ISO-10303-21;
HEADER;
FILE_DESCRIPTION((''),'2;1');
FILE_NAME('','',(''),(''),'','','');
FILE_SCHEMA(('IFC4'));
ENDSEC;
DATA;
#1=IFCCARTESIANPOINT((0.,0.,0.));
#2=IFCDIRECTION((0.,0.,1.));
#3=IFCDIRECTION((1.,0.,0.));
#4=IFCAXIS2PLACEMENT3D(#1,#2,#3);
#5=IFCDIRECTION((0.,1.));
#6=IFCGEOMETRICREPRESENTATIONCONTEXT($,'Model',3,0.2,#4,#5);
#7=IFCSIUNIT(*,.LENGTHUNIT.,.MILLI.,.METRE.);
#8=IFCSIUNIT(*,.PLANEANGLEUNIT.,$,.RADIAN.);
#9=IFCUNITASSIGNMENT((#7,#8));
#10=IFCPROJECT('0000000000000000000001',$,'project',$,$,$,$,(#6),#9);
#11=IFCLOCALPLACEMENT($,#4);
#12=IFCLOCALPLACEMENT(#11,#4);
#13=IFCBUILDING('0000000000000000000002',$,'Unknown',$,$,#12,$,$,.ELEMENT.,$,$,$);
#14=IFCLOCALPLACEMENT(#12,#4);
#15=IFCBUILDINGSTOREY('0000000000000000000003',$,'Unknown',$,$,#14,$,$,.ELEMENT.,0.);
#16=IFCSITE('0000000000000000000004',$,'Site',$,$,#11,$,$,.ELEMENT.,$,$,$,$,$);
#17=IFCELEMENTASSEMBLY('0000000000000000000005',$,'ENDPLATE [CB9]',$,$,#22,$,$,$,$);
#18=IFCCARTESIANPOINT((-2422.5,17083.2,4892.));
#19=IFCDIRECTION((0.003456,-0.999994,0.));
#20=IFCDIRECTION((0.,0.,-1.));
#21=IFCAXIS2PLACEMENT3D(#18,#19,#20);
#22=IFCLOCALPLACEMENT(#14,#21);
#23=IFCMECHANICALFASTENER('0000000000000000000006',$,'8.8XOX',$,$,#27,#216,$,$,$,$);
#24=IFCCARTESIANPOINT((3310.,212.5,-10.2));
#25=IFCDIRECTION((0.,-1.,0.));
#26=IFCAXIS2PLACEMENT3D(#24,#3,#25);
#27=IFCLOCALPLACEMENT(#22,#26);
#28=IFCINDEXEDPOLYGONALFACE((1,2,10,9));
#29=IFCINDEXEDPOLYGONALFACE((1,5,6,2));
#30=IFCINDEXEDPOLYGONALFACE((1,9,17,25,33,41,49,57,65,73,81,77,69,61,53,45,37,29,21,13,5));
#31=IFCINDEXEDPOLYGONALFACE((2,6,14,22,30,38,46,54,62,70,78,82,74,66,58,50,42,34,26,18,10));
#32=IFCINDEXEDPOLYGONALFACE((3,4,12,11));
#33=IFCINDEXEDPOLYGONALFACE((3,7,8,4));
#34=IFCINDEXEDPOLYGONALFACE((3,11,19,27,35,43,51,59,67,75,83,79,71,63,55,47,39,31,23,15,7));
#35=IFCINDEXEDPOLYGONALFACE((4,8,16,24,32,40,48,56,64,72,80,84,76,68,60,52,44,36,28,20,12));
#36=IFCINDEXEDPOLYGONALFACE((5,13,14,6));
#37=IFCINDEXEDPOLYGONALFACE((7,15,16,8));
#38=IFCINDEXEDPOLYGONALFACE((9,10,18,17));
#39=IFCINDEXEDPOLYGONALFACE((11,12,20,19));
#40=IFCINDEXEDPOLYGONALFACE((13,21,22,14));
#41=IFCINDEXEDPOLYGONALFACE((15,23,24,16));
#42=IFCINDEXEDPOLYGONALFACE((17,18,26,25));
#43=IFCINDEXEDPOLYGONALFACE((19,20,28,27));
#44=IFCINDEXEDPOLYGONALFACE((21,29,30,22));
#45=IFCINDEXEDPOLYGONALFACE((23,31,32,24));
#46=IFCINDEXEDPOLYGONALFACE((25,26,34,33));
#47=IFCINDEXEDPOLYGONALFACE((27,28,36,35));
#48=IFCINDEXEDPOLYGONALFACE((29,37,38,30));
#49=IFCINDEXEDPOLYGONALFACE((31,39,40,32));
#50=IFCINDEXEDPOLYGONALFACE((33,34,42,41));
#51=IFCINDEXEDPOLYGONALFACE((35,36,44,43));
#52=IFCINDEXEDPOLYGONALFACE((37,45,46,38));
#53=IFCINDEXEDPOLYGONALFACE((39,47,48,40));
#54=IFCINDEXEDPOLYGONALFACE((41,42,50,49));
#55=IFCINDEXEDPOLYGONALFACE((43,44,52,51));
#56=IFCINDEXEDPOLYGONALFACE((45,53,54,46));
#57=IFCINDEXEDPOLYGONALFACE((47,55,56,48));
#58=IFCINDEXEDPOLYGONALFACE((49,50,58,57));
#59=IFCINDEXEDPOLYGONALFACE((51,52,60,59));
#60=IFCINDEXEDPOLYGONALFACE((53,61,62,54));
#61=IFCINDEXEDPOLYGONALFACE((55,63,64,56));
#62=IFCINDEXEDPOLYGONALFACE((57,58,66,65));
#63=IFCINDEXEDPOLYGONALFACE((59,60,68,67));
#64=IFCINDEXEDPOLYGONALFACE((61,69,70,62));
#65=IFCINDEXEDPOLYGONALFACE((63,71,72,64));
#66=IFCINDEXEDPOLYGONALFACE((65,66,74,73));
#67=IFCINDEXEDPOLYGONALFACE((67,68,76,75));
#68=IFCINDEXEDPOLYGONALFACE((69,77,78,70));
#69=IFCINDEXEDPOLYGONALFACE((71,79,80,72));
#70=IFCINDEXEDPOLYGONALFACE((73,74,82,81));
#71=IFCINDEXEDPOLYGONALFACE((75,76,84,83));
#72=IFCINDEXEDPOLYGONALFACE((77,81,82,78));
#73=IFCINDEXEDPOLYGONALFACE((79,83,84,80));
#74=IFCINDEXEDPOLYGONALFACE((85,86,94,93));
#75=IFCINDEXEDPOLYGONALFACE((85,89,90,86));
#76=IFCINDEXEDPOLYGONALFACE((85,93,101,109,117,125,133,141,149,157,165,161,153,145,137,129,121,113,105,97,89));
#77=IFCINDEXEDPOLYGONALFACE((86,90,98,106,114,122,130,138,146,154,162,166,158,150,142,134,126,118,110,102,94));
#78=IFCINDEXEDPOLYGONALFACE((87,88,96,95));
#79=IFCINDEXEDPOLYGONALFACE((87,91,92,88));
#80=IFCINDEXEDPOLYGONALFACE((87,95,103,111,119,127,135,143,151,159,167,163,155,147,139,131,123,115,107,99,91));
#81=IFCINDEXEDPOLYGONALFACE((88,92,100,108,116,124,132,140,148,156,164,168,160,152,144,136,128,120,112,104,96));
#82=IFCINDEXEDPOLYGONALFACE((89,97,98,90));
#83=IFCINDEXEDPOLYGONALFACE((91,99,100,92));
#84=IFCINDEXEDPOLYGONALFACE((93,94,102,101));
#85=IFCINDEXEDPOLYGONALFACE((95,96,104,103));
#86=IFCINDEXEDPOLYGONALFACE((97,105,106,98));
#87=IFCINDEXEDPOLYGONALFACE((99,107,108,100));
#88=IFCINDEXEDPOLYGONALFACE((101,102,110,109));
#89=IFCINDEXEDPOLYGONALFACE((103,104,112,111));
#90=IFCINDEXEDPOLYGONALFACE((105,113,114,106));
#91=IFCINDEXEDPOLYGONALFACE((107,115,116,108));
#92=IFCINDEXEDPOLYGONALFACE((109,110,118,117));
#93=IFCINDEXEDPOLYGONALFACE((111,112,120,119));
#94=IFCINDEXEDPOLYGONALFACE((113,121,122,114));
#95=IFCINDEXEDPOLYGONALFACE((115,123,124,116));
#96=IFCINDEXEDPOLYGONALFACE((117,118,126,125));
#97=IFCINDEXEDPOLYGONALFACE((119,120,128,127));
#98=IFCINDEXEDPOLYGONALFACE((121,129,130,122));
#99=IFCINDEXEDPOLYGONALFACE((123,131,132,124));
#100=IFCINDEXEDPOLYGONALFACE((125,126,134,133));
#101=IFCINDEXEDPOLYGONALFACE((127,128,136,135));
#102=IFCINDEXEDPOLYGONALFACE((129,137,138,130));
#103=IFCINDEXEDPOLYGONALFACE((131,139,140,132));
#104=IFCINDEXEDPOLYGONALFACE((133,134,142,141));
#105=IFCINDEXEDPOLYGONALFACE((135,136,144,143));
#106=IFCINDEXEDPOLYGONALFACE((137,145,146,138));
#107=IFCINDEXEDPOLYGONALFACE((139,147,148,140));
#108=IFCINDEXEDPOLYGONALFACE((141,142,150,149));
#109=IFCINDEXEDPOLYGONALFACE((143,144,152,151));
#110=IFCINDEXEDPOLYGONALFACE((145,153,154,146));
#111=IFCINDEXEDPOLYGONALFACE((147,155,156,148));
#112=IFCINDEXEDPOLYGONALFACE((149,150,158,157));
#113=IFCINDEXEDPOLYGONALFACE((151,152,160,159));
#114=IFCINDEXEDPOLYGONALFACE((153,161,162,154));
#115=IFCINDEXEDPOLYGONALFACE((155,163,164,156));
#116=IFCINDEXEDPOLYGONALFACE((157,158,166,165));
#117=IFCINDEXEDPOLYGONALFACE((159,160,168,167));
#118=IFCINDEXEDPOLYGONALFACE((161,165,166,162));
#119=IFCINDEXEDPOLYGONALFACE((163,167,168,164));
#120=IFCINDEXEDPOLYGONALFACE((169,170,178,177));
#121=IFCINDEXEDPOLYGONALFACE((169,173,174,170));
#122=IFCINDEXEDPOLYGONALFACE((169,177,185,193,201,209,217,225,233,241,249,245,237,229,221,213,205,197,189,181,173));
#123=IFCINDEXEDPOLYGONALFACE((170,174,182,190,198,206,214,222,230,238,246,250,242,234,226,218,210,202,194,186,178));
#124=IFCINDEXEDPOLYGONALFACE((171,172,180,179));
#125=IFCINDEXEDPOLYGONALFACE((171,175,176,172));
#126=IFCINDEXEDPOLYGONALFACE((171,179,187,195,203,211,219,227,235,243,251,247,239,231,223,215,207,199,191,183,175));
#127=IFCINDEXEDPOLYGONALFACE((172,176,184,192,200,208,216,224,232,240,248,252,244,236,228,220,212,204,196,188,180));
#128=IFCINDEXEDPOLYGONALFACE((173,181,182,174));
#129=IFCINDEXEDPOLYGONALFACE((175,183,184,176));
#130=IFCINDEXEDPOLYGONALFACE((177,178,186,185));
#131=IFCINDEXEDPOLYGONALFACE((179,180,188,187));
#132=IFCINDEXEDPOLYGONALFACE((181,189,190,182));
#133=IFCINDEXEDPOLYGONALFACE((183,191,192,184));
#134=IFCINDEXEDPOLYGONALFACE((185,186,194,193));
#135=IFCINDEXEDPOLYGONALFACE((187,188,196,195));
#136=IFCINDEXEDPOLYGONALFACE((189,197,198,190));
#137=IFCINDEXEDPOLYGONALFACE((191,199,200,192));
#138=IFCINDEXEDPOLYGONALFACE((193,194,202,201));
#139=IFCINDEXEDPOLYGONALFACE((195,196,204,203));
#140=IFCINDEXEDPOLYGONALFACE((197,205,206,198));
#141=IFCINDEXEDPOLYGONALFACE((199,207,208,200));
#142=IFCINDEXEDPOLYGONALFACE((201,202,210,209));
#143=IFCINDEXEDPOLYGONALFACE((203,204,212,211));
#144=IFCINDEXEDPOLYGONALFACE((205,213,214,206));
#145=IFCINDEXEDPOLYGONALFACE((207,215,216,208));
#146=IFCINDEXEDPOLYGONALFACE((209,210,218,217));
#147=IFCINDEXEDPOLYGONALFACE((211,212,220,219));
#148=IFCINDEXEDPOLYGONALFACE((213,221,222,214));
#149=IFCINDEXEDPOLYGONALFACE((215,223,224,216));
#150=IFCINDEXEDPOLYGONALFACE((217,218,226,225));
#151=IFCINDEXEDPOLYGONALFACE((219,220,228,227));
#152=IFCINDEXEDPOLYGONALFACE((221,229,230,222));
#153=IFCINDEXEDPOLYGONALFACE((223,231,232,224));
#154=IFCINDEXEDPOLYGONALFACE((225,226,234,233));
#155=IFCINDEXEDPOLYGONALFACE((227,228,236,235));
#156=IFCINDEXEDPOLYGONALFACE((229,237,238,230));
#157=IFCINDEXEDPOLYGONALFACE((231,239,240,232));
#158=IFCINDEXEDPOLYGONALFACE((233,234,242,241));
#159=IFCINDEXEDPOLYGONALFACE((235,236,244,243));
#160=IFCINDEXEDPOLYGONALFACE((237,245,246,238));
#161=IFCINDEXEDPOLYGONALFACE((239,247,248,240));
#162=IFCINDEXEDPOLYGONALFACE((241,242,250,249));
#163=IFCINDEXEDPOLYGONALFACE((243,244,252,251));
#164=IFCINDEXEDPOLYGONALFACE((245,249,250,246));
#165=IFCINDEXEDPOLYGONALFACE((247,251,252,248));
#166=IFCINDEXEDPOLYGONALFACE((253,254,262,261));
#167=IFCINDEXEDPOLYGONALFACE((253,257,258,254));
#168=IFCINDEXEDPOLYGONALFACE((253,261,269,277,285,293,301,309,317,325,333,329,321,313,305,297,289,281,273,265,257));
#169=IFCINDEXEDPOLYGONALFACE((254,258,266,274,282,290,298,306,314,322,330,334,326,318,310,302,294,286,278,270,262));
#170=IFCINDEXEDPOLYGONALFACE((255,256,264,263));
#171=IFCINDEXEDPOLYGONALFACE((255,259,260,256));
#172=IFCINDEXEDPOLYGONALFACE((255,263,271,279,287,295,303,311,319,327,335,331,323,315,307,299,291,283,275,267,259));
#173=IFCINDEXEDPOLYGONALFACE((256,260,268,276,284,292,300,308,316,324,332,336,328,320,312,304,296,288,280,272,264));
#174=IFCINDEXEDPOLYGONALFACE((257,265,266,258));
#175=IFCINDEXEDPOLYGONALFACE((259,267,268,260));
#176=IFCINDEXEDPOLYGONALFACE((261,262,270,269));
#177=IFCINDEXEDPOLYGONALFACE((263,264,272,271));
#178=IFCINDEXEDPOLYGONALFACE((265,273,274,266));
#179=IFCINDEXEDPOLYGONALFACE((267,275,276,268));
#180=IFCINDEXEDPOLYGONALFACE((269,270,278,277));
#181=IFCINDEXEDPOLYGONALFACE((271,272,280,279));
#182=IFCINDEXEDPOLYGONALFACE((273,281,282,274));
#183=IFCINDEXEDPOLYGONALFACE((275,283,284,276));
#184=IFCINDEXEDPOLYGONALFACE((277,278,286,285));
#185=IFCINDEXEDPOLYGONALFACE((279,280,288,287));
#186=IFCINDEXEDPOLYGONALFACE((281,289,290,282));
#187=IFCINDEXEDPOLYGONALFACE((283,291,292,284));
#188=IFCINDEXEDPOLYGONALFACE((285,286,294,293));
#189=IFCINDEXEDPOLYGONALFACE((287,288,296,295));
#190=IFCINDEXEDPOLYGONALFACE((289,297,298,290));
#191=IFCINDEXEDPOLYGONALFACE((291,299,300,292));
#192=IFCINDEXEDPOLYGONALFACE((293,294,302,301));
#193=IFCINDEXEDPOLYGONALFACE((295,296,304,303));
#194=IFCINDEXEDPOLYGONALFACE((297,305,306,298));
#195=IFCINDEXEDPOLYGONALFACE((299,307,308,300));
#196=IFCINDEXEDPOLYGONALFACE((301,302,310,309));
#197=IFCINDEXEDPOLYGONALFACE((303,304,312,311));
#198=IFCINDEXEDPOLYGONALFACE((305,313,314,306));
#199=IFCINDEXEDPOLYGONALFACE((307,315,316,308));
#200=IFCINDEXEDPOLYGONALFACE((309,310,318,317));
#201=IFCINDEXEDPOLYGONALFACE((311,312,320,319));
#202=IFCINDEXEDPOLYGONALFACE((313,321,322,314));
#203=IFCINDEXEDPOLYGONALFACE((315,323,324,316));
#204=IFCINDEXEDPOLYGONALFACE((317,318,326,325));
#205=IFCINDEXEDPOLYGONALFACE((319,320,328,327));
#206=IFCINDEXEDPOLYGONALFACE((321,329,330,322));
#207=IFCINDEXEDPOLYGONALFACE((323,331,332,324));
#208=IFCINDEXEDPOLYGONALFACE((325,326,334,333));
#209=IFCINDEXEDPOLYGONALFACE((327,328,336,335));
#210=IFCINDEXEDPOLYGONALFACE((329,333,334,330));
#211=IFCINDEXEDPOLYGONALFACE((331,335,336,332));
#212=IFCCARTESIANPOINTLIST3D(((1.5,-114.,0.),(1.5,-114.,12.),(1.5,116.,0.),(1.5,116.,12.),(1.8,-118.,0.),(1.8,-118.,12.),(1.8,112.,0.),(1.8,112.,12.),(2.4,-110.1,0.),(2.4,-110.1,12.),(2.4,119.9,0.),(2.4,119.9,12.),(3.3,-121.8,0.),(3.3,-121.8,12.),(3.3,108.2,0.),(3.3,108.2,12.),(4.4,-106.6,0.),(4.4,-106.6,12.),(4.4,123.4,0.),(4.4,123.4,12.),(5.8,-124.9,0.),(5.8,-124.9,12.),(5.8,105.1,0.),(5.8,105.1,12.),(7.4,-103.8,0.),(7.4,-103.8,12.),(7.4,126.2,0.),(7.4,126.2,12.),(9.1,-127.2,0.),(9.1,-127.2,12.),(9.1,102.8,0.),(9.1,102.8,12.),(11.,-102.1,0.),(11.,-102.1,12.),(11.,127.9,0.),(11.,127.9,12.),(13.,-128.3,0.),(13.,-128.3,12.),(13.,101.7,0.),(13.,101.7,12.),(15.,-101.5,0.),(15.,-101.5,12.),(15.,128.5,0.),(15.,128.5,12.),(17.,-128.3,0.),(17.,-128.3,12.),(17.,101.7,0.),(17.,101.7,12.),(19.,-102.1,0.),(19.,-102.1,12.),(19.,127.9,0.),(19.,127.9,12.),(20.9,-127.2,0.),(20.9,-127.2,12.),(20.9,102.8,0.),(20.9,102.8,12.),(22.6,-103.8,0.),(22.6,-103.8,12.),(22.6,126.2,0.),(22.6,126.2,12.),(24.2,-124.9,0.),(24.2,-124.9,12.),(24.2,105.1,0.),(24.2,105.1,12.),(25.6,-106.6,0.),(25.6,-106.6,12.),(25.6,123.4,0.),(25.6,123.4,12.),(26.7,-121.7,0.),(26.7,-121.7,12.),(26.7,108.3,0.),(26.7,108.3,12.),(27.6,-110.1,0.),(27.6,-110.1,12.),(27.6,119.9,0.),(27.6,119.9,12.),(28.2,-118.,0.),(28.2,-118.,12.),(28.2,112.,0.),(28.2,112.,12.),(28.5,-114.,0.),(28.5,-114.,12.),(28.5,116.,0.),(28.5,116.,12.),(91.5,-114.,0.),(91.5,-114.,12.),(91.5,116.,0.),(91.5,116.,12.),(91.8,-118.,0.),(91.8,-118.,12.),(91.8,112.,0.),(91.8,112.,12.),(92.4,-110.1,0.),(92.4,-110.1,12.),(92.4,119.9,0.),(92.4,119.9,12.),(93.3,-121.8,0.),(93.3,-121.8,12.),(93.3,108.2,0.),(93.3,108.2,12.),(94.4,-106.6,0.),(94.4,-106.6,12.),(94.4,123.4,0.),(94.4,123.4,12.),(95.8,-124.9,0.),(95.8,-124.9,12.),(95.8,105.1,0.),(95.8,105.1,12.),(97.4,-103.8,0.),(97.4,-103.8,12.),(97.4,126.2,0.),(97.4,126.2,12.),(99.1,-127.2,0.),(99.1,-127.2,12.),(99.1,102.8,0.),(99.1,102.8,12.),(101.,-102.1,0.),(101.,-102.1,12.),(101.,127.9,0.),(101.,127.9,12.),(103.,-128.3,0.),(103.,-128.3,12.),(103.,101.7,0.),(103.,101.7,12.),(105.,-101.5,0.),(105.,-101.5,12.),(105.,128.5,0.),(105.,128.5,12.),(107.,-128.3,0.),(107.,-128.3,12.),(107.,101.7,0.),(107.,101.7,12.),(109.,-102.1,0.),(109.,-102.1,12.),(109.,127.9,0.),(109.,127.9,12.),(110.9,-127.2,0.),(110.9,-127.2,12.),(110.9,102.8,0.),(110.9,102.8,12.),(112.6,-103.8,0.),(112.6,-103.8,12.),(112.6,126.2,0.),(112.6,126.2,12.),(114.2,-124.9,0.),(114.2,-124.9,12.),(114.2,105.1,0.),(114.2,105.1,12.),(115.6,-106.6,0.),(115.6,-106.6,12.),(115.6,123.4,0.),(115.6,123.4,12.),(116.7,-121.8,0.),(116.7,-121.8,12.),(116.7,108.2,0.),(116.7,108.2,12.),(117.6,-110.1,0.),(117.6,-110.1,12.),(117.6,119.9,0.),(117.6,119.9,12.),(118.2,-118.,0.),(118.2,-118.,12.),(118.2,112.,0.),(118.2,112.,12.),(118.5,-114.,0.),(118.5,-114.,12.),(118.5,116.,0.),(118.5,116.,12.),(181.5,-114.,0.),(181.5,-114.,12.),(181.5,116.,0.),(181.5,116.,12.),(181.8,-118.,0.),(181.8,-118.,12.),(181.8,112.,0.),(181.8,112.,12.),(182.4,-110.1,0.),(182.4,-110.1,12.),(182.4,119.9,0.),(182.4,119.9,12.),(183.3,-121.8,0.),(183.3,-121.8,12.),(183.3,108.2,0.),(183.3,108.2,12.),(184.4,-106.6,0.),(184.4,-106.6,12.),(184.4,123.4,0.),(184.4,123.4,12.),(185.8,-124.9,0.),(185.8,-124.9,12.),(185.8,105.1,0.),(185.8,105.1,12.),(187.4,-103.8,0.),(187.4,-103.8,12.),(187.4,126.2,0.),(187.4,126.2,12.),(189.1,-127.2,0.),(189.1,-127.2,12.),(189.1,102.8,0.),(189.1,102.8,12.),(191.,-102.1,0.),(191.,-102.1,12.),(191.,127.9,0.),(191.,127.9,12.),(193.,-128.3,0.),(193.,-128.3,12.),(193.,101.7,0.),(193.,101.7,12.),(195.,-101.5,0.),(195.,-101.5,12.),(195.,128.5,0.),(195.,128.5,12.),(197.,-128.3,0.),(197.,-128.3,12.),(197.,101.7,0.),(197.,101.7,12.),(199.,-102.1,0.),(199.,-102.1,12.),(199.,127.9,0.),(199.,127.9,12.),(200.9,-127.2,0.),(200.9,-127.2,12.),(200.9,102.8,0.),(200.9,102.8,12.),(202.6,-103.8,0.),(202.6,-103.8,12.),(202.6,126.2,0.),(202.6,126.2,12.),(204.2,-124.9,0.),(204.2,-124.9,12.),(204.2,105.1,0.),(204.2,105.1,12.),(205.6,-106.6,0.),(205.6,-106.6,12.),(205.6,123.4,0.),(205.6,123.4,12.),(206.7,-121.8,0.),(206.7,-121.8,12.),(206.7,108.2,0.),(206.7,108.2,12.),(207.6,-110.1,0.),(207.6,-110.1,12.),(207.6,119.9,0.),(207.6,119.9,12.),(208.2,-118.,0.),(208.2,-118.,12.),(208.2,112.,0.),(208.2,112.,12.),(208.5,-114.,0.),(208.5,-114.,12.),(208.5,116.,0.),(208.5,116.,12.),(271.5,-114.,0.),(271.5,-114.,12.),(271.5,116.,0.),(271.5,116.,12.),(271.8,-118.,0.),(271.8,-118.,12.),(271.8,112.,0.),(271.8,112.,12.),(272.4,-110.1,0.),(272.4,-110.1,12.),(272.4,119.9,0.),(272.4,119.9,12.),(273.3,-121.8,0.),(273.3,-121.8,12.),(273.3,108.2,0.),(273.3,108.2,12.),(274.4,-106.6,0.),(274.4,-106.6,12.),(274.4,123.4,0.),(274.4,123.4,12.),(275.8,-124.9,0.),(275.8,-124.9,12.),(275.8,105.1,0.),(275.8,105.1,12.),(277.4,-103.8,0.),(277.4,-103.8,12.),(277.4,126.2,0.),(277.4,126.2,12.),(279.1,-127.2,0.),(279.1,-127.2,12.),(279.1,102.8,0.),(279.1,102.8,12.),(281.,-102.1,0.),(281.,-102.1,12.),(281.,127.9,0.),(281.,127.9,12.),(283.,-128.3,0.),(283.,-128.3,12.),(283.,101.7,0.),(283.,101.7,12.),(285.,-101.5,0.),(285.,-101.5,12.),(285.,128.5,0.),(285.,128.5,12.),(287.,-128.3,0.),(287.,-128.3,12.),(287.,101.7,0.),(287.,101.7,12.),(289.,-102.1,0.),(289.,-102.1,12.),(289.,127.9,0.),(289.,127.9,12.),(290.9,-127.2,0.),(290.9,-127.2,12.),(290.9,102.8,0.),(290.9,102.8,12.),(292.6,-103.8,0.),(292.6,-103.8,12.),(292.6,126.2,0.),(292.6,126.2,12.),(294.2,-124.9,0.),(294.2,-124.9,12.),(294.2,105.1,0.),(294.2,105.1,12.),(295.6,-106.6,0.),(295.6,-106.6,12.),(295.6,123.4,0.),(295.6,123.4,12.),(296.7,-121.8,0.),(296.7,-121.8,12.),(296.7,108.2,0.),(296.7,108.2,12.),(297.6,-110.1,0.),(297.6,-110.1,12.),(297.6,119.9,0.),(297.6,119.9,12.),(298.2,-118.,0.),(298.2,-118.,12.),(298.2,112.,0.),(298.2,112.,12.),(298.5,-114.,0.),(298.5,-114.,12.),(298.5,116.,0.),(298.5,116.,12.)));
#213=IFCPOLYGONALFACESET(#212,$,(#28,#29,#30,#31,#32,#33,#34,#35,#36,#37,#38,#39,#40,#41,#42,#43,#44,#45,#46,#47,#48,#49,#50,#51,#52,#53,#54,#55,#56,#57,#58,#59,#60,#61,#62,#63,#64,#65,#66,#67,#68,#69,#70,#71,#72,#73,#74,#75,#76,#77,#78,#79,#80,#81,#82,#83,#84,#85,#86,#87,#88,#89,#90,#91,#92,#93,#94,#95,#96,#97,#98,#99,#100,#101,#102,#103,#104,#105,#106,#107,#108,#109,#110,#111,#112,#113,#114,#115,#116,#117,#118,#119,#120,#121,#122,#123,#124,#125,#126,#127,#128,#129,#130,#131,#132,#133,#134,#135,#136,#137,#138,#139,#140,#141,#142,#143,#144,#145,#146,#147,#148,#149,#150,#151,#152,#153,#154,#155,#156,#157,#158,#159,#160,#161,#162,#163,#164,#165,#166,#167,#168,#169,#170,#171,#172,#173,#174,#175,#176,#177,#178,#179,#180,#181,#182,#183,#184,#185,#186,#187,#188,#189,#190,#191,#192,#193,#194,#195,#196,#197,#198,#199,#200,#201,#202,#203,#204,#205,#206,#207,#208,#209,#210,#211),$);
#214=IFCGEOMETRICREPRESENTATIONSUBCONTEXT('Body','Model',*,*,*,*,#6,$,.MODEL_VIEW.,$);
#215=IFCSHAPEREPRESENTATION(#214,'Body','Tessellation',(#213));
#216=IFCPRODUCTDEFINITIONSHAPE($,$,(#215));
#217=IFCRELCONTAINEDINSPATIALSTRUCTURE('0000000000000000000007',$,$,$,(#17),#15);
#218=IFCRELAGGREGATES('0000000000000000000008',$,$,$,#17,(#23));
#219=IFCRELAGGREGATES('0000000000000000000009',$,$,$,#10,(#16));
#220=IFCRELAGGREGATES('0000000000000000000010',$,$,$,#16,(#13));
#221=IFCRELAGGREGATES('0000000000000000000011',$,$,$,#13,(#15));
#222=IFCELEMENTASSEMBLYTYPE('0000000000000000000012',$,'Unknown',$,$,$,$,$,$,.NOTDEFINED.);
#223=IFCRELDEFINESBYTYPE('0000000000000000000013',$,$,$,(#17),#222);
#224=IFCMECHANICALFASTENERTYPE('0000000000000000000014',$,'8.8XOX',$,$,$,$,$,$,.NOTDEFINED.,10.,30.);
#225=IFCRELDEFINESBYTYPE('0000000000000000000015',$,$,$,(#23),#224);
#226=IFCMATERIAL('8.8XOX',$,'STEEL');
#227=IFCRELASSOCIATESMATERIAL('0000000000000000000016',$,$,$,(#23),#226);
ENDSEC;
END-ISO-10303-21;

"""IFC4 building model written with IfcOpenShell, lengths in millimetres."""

from ifc_helpers import new_model, si_unit, direction, frame, origin_with_axes, origin_2d_with_axis, place, context, subcontext, project, spatial, circle, extrude, source, transform, mapped, material, type_object, element, aggregate, save


model = new_model("IFC4")

# Units and contexts
model_context = context("Model", 3, precision=0.2, world=origin_with_axes(), true_north=direction((0.0, 1.0)))
body_context = subcontext(model_context, "Body", "Model", "MODEL_VIEW")
ifc_project = project(units=[si_unit("LENGTHUNIT", "METRE", prefix="MILLI"), si_unit("PLANEANGLEUNIT", "RADIAN")], contexts=[model_context])

# Site, building, storey
site_placement = place(None, origin_with_axes())
site = spatial("IfcSite", under=ifc_project, at=site_placement, Name="Site", CompositionType="ELEMENT")
building_placement = place(site_placement, origin_with_axes())
building = spatial("IfcBuilding", under=site, at=building_placement, Name="Unknown", CompositionType="ELEMENT")
storey_placement = place(building_placement, origin_with_axes())
storey = spatial("IfcBuildingStorey", under=building, at=storey_placement, Name="Unknown", CompositionType="ELEMENT", Elevation=0.0)

# Element assembly
element_assembly_type = type_object("IfcElementAssemblyType", Name="Unknown", PredefinedType="NOTDEFINED")
assembly_1_placement = place(storey_placement, frame((-2422.5, 17083.2, 4892.0), z_axis=(0.003456, -0.999994, 0.0), x_axis=(0.0, 0.0, -1.0)))
assembly_1 = element("IfcElementAssembly", 1, at=assembly_1_placement, inside=storey, type_object=element_assembly_type, Name="ENDPLATE [CB9]")

# Mechanical fastener
ifc_material_1 = material(Name="8.8XOX", Category="STEEL")
mechanical_fastener_type = type_object("IfcMechanicalFastenerType", Name="8.8XOX", NominalDiameter=10.0, NominalLength=30.0, PredefinedType="NOTDEFINED")
shared_shape = source(origin_with_axes(), body_context, "Body", "SweptSolid", [
    extrude(circle(Radius=13.5, at=origin_2d_with_axis()), frame((0.0, 0.0, 12.0), z_axis=(0.0, 0.0, -1.0), x_axis=(0.0, 1.0, 0.0)), (0.0, 0.0, 1.0), 12.0),
])
mechanical_fastener_placement = place(assembly_1_placement, frame((3310.0, 212.5, -10.2), z_axis=(1.0, 0.0, 0.0), x_axis=(0.0, -1.0, 0.0)))
mechanical_fastener = element("IfcMechanicalFastener", 2, at=mechanical_fastener_placement, type_object=mechanical_fastener_type, material=ifc_material_1, Name="8.8XOX", context=body_context, shape_type="MappedRepresentation", body=[
    mapped(shared_shape, transform((15.0, -115.0, 0.0))),
    mapped(shared_shape, transform((15.0, 115.0, 0.0))),
    mapped(shared_shape, transform((105.0, -115.0, 0.0))),
    mapped(shared_shape, transform((105.0, 115.0, 0.0))),
    mapped(shared_shape, transform((195.0, -115.0, 0.0))),
    mapped(shared_shape, transform((195.0, 115.0, 0.0))),
    mapped(shared_shape, transform((285.0, -115.0, 0.0))),
    mapped(shared_shape, transform((285.0, 115.0, 0.0))),
])
aggregate(assembly_1, [mechanical_fastener])

save(model, "model.ifc")
